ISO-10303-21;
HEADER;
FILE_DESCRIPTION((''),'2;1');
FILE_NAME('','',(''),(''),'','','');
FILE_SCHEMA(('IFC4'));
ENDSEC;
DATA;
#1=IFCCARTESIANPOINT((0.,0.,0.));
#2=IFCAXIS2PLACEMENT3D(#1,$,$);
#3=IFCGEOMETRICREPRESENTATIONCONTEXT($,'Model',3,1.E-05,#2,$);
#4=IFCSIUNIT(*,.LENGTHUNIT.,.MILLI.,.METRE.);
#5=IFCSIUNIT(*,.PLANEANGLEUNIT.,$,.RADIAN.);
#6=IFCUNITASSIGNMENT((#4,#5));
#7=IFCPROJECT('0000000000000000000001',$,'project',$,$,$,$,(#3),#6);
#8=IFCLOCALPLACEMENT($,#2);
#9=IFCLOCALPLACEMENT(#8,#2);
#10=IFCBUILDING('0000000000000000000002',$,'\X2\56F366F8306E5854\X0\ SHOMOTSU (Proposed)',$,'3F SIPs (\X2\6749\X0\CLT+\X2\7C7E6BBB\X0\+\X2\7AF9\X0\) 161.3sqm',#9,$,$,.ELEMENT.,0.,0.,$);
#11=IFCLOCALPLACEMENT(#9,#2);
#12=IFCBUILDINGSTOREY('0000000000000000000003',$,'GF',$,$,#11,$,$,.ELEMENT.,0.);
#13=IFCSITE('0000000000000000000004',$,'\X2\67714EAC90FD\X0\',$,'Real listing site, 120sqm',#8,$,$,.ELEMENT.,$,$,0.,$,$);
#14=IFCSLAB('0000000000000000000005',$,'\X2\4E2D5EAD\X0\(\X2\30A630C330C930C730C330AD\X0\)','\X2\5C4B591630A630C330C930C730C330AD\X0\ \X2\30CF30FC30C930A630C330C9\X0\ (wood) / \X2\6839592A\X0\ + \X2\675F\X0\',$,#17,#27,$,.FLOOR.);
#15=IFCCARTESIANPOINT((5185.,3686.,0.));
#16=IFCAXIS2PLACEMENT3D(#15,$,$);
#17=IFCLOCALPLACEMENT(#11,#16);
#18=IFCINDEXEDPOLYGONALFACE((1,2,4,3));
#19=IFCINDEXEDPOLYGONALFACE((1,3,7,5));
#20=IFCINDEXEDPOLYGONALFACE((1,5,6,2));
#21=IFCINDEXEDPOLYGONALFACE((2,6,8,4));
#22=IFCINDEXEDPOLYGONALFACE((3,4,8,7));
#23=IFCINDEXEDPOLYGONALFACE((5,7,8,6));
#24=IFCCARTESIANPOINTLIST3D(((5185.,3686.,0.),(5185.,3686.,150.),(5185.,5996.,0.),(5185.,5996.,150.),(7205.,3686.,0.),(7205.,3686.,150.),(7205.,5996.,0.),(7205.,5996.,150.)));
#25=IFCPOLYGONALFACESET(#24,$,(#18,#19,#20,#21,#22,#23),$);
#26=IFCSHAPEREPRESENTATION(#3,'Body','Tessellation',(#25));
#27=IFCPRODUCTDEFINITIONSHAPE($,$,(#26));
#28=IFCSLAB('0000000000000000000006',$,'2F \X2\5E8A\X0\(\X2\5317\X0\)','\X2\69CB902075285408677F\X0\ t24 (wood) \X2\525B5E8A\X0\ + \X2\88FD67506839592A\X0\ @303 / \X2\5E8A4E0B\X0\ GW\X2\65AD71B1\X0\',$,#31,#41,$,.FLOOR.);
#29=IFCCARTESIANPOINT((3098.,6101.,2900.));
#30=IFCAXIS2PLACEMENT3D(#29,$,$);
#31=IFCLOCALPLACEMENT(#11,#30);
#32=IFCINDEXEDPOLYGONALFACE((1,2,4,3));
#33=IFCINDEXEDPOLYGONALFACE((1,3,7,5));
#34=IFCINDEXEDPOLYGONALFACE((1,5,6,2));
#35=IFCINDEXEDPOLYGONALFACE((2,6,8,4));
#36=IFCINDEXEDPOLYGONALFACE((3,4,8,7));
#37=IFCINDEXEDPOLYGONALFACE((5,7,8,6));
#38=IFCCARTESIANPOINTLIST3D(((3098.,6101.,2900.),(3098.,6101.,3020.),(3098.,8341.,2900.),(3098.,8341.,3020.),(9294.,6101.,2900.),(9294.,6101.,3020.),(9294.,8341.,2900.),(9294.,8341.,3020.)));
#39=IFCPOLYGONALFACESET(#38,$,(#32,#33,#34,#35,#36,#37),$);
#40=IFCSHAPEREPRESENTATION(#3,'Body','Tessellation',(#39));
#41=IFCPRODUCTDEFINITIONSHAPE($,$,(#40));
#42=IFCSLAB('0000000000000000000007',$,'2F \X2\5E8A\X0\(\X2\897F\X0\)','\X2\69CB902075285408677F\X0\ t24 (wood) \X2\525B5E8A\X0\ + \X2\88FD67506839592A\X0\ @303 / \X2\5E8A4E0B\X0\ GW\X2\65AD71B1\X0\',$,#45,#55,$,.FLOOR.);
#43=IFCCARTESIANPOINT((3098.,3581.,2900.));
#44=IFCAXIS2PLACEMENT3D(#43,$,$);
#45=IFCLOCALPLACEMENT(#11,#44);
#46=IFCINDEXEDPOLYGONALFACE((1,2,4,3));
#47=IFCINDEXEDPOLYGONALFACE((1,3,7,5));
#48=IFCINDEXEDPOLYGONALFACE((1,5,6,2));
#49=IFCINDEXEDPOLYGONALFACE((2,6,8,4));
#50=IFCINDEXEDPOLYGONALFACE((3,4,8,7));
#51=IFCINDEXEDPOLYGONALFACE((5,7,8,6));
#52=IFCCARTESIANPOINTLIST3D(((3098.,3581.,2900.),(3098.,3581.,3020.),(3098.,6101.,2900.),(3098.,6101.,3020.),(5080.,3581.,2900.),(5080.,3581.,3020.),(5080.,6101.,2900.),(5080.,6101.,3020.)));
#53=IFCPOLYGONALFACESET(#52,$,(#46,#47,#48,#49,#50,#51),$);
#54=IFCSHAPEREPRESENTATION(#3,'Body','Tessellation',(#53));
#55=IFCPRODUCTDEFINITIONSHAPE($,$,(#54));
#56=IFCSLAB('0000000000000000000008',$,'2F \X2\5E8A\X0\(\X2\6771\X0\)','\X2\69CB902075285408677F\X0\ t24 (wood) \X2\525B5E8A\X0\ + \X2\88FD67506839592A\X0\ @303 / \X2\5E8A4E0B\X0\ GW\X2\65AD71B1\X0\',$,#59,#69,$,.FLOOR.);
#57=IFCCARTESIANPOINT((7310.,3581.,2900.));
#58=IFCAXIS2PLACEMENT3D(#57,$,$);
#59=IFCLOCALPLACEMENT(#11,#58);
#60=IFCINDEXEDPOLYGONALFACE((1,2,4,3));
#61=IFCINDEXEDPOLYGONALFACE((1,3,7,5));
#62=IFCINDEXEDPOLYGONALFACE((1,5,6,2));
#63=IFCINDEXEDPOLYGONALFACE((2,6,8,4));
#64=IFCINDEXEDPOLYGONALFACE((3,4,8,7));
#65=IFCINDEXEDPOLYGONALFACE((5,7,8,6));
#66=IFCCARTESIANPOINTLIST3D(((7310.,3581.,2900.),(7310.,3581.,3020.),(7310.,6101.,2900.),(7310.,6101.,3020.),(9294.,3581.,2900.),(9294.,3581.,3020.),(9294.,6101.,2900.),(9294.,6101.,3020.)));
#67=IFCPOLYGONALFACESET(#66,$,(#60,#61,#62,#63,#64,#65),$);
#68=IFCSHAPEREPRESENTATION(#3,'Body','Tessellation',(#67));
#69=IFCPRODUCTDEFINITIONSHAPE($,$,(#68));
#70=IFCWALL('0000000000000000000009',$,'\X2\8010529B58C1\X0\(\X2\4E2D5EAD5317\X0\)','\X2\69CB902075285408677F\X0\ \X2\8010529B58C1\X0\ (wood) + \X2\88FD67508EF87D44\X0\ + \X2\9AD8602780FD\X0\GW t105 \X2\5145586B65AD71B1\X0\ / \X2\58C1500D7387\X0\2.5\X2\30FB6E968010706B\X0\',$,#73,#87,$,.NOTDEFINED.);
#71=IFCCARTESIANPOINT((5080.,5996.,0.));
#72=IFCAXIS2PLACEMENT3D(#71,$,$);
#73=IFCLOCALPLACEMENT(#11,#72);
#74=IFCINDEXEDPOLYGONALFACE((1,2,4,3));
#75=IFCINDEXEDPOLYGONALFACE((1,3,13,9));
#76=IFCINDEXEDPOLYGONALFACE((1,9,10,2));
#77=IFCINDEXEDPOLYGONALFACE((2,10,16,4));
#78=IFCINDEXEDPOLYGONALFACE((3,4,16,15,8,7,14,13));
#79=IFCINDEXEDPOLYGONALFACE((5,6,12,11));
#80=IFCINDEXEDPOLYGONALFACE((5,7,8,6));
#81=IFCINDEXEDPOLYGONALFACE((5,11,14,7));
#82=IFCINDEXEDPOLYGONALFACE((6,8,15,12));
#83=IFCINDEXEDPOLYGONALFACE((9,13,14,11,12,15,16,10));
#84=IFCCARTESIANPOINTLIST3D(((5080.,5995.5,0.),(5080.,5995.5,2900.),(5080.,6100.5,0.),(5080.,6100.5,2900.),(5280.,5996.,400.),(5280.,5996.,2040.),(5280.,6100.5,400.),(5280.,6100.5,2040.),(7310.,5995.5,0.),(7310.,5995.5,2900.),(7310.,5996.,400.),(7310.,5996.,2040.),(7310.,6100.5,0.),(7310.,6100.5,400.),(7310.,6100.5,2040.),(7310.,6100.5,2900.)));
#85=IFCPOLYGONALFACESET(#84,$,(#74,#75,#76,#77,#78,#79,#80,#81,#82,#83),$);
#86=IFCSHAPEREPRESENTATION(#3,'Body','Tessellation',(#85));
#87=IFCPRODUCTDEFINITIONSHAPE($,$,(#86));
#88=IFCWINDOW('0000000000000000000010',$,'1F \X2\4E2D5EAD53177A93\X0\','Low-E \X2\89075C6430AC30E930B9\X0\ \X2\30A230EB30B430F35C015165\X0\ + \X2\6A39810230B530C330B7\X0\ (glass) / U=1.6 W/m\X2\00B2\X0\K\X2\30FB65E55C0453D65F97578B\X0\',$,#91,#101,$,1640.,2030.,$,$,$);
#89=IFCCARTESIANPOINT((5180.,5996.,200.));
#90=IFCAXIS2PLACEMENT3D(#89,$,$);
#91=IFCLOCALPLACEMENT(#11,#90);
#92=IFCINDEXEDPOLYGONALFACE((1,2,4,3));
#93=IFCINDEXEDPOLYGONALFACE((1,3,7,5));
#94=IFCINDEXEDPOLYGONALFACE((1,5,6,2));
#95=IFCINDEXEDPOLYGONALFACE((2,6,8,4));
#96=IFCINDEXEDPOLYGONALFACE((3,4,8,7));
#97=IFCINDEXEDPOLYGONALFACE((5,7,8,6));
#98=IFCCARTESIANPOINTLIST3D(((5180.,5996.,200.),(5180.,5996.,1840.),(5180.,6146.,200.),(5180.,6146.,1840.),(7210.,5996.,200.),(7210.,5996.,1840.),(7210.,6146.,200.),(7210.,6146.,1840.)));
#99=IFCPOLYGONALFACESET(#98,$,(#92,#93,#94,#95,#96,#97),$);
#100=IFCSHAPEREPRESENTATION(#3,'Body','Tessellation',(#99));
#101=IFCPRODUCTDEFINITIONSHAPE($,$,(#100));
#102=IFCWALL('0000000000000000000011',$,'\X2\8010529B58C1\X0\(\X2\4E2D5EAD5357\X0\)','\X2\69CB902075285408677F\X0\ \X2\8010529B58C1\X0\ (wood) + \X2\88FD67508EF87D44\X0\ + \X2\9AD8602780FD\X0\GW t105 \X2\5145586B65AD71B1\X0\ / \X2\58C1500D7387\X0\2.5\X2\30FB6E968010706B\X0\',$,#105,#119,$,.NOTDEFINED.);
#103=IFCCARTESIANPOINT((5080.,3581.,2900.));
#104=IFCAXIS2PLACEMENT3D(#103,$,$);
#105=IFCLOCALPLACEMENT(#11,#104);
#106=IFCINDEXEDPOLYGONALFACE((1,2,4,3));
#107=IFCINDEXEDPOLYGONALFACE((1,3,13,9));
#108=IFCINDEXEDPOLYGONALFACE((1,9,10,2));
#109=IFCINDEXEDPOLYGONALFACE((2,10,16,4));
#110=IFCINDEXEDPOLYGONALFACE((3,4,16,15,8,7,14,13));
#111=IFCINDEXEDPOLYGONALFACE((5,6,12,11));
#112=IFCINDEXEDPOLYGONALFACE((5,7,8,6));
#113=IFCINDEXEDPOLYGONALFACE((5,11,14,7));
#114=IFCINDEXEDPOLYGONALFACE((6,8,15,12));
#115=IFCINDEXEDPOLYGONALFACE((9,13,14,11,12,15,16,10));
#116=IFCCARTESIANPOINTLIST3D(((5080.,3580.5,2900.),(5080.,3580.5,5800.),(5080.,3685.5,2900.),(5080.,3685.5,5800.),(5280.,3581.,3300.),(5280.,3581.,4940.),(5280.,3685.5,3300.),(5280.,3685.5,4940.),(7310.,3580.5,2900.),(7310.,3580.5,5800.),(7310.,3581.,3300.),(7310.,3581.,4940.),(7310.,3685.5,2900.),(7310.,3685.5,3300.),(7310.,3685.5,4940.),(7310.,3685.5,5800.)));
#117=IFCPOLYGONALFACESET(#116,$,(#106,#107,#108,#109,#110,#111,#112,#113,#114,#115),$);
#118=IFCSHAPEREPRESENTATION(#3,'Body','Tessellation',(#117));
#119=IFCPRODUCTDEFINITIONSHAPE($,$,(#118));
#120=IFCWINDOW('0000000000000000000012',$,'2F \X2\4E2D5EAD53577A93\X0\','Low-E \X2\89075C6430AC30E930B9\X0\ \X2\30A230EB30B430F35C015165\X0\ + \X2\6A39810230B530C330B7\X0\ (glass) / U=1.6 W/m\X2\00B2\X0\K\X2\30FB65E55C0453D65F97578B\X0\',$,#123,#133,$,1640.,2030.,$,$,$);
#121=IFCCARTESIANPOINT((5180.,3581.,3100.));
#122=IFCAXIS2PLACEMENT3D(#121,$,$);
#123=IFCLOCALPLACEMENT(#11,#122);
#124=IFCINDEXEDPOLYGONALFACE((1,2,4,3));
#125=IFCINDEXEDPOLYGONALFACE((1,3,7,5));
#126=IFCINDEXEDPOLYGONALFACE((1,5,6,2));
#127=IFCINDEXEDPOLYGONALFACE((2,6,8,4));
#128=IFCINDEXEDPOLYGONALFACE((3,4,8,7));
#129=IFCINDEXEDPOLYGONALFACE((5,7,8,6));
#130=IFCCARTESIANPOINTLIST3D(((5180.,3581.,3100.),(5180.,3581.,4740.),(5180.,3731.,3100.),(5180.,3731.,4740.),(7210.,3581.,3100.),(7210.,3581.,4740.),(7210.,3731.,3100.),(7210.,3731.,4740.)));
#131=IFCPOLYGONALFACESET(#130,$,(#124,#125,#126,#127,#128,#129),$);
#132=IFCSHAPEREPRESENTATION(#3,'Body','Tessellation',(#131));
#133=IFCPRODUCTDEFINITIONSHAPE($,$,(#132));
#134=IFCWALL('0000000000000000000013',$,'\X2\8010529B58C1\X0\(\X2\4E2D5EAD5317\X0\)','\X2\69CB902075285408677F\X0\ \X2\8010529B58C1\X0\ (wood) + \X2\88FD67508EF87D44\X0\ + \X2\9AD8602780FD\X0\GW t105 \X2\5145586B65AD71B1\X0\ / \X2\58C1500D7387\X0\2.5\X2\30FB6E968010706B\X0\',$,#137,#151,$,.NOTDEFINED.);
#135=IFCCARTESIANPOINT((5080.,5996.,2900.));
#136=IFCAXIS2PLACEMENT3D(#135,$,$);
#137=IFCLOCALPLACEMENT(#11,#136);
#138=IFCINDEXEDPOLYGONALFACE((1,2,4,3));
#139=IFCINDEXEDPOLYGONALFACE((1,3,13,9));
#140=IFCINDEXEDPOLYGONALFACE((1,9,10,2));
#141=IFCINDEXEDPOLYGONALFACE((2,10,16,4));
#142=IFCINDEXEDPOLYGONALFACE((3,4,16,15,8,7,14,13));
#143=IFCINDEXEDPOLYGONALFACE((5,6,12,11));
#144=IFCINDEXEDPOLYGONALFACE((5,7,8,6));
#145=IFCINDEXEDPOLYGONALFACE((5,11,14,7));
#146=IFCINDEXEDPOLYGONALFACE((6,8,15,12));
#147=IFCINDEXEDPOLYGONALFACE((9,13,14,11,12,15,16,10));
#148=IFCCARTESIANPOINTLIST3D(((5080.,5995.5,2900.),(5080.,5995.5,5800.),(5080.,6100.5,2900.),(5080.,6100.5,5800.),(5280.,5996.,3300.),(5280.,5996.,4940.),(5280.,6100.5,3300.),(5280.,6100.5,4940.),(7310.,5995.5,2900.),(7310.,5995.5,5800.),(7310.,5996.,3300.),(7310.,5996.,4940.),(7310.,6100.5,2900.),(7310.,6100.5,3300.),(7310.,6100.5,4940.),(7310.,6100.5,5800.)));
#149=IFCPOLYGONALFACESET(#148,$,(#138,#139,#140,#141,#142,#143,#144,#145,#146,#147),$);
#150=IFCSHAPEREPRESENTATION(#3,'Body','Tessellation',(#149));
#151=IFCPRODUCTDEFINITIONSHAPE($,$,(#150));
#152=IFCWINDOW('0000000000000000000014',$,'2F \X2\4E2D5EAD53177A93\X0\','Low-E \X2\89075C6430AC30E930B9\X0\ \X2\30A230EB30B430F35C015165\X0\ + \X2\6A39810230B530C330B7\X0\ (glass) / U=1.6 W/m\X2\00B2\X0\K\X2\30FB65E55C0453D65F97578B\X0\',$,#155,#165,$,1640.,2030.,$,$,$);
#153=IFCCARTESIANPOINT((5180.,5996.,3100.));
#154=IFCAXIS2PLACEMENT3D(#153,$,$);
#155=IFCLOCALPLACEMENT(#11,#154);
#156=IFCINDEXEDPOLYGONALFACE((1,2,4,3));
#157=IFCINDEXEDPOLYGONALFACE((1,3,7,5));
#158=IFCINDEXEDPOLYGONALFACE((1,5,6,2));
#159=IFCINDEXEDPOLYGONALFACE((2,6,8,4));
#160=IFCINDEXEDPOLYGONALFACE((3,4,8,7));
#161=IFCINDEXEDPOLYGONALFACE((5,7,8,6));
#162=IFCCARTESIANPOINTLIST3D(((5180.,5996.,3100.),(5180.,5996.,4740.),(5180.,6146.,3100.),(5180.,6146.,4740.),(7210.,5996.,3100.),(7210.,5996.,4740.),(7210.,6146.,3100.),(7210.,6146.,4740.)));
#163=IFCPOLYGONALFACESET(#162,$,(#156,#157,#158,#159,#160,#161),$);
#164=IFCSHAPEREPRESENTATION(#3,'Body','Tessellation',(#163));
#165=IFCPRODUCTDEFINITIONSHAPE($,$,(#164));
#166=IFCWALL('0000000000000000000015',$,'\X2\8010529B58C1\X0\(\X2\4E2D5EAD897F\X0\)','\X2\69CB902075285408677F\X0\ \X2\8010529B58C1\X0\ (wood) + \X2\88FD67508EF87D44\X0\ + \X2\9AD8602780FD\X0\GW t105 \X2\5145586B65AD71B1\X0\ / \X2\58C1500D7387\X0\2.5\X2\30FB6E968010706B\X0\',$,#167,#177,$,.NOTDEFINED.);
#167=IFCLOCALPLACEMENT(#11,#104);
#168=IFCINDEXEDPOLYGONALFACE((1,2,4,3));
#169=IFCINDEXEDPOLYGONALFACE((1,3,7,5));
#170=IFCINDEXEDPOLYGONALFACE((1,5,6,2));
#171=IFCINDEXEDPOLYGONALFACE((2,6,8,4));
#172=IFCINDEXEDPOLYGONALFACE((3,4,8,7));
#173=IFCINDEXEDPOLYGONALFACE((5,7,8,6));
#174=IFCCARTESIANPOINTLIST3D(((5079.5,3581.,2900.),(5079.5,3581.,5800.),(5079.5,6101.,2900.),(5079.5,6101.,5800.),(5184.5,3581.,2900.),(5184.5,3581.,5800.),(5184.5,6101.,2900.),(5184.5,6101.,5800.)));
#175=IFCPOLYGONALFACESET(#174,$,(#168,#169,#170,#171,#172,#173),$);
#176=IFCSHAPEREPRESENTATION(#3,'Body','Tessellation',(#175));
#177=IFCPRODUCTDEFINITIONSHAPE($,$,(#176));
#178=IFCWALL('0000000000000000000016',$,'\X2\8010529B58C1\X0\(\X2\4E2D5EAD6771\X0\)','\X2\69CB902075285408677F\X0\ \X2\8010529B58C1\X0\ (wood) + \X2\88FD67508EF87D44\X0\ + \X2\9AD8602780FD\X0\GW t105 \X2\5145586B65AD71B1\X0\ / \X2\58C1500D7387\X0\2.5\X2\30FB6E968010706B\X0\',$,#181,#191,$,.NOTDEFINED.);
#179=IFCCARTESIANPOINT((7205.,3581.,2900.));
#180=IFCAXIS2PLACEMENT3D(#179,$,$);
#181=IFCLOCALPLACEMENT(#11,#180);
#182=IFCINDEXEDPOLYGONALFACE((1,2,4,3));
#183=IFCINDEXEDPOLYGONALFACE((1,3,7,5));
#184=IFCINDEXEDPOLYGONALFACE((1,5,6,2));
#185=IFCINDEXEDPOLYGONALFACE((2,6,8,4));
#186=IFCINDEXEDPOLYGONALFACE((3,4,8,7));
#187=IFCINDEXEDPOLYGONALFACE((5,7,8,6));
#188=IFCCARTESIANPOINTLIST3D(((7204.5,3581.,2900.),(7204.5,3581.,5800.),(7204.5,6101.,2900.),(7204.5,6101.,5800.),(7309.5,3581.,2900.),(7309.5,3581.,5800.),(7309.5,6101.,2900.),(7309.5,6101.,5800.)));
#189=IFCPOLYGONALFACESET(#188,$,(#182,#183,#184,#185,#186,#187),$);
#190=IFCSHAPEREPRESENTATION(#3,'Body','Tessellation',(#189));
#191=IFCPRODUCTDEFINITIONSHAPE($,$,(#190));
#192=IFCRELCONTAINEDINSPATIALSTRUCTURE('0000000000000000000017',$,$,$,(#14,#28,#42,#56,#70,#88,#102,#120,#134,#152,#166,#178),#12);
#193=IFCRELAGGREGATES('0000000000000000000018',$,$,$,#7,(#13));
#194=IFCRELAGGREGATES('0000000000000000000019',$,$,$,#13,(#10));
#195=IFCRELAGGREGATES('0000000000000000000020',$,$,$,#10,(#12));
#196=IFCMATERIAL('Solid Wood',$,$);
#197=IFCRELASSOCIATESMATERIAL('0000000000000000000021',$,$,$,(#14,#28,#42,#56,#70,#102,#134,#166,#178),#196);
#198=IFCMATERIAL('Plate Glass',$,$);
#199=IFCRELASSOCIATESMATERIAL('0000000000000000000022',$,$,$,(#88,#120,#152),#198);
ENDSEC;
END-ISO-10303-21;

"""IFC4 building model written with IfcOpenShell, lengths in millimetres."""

from ifc_helpers import new_model, si_unit, frame, frame_2d, origin, place, context, project, spatial, rectangle, extrude, material, element, fill, save


model = new_model("IFC4")

# Units and contexts
model_context = context("Model", 3, precision=1e-05, world=origin())
ifc_project = project(units=[si_unit("LENGTHUNIT", "METRE", prefix="MILLI"), si_unit("PLANEANGLEUNIT", "RADIAN")], contexts=[model_context])

# Site, building, storey
site_placement = place(None, origin())
site = spatial("IfcSite", under=ifc_project, at=site_placement, Name="東京都", ObjectType="Real listing site, 120sqm", CompositionType="ELEMENT", RefElevation=0.0)
building_placement = place(site_placement, origin())
building = spatial("IfcBuilding", under=site, at=building_placement, Name="図書の塔 SHOMOTSU (Proposed)", ObjectType="3F SIPs (杉CLT+籾殻+竹) 161.3sqm", CompositionType="ELEMENT", ElevationOfRefHeight=0.0, ElevationOfTerrain=0.0)
storey_placement = place(building_placement, origin())
storey = spatial("IfcBuildingStorey", under=building, at=storey_placement, Name="GF", CompositionType="ELEMENT", Elevation=0.0)

# Slabs
ifc_material_1 = material(Name="Solid Wood")
slab_1_placement = place(storey_placement, frame((5185.0, 3686.0, 0.0)))
element("IfcSlab", 1, at=slab_1_placement, inside=storey, material=ifc_material_1, Name="中庭(ウッドデッキ)", Description="屋外ウッドデッキ ハードウッド (wood) / 根太 + 束", PredefinedType="FLOOR", context=model_context, shape_type="SweptSolid", body=[
    extrude(rectangle(XDim=2020.0, YDim=2310.0, at=frame_2d((1010.0, 1155.0))), frame((5185.0, 3686.0, 0.0)), (0.0, 0.0, 1.0), 150.0),
])
slab_2_placement = place(storey_placement, frame((3098.0, 6101.0, 2900.0)))
element("IfcSlab", 2, at=slab_2_placement, inside=storey, material=ifc_material_1, Name="2F 床(北)", Description="構造用合板 t24 (wood) 剛床 + 製材根太 @303 / 床下 GW断熱", PredefinedType="FLOOR", context=model_context, shape_type="SweptSolid", body=[
    extrude(rectangle(XDim=6196.0, YDim=2240.0, at=frame_2d((3098.0, 1120.0))), frame((3098.0, 6101.0, 2900.0)), (0.0, 0.0, 1.0), 120.0),
])
slab_3_placement = place(storey_placement, frame((3098.0, 3581.0, 2900.0)))
element("IfcSlab", 3, at=slab_3_placement, inside=storey, material=ifc_material_1, Name="2F 床(西)", Description="構造用合板 t24 (wood) 剛床 + 製材根太 @303 / 床下 GW断熱", PredefinedType="FLOOR", context=model_context, shape_type="SweptSolid", body=[
    extrude(rectangle(XDim=1982.0, YDim=2520.0, at=frame_2d((991.0, 1260.0))), frame((3098.0, 3581.0, 2900.0)), (0.0, 0.0, 1.0), 120.0),
])
slab_4_placement = place(storey_placement, frame((7310.0, 3581.0, 2900.0)))
element("IfcSlab", 4, at=slab_4_placement, inside=storey, material=ifc_material_1, Name="2F 床(東)", Description="構造用合板 t24 (wood) 剛床 + 製材根太 @303 / 床下 GW断熱", PredefinedType="FLOOR", context=model_context, shape_type="SweptSolid", body=[
    extrude(rectangle(XDim=1984.0, YDim=2520.0, at=frame_2d((992.0, 1260.0))), frame((7310.0, 3581.0, 2900.0)), (0.0, 0.0, 1.0), 120.0),
])

# Wall, opening, window
wall_1_placement = place(storey_placement, frame((5080.0, 5996.0, 0.0)))
wall_1 = element("IfcWall", 5, at=wall_1_placement, inside=storey, material=ifc_material_1, Name="耐力壁(中庭北)", Description="構造用合板 耐力壁 (wood) + 製材軸組 + 高性能GW t105 充填断熱 / 壁倍率2.5・準耐火", PredefinedType="NOTDEFINED", context=model_context, shape_type="SweptSolid", body=[
    extrude(rectangle(XDim=2230.0, YDim=105.0, at=frame_2d((1115.0, 52.0))), frame((5080.0, 5996.0, 0.0)), (0.0, 0.0, 1.0), 2900.0),
])
opening_1_placement = place(storey_placement, frame((5180.0, 5996.0, 200.0)))
opening_1 = element("IfcOpeningElement", 6, at=opening_1_placement, cuts=wall_1, PredefinedType="NOTDEFINED", context=model_context, shape_type="SweptSolid", body=[
    extrude(rectangle(XDim=2030.0, YDim=150.0, at=frame_2d((1015.0, 75.0))), frame((5180.0, 5996.0, 200.0)), (0.0, 0.0, 1.0), 1640.0),
])
ifc_material_2 = material(Name="Plate Glass")
window_1_placement = place(storey_placement, frame((5180.0, 5996.0, 200.0)))
window_1 = element("IfcWindow", 7, at=window_1_placement, inside=storey, material=ifc_material_2, Name="1F 中庭北窓", Description="Low-E 複層ガラス アルゴン封入 + 樹脂サッシ (glass) / U=1.6 W/m²K・日射取得型", OverallHeight=1640.0, OverallWidth=2030.0, context=model_context, shape_type="SweptSolid", body=[
    extrude(rectangle(XDim=2030.0, YDim=150.0, at=frame_2d((1015.0, 75.0))), frame((5180.0, 5996.0, 200.0)), (0.0, 0.0, 1.0), 1640.0),
])
fill(opening_1, window_1)

# Walls, openings, windows
wall_2_placement = place(storey_placement, frame((5080.0, 3581.0, 2900.0)))
wall_2 = element("IfcWall", 8, at=wall_2_placement, inside=storey, material=ifc_material_1, Name="耐力壁(中庭南)", Description="構造用合板 耐力壁 (wood) + 製材軸組 + 高性能GW t105 充填断熱 / 壁倍率2.5・準耐火", PredefinedType="NOTDEFINED", context=model_context, shape_type="SweptSolid", body=[
    extrude(rectangle(XDim=2230.0, YDim=105.0, at=frame_2d((1115.0, 52.0))), frame((5080.0, 3581.0, 2900.0)), (0.0, 0.0, 1.0), 2900.0),
])
opening_2_placement = place(storey_placement, frame((5180.0, 3581.0, 3100.0)))
opening_2 = element("IfcOpeningElement", 9, at=opening_2_placement, cuts=wall_2, PredefinedType="NOTDEFINED", context=model_context, shape_type="SweptSolid", body=[
    extrude(rectangle(XDim=2030.0, YDim=150.0, at=frame_2d((1015.0, 75.0))), frame((5180.0, 3581.0, 3100.0)), (0.0, 0.0, 1.0), 1640.0),
])
window_2_placement = place(storey_placement, frame((5180.0, 3581.0, 3100.0)))
window_2 = element("IfcWindow", 10, at=window_2_placement, inside=storey, material=ifc_material_2, Name="2F 中庭南窓", Description="Low-E 複層ガラス アルゴン封入 + 樹脂サッシ (glass) / U=1.6 W/m²K・日射取得型", OverallHeight=1640.0, OverallWidth=2030.0, context=model_context, shape_type="SweptSolid", body=[
    extrude(rectangle(XDim=2030.0, YDim=150.0, at=frame_2d((1015.0, 75.0))), frame((5180.0, 3581.0, 3100.0)), (0.0, 0.0, 1.0), 1640.0),
])
fill(opening_2, window_2)
wall_3_placement = place(storey_placement, frame((5080.0, 5996.0, 2900.0)))
wall_3 = element("IfcWall", 11, at=wall_3_placement, inside=storey, material=ifc_material_1, Name="耐力壁(中庭北)", Description="構造用合板 耐力壁 (wood) + 製材軸組 + 高性能GW t105 充填断熱 / 壁倍率2.5・準耐火", PredefinedType="NOTDEFINED", context=model_context, shape_type="SweptSolid", body=[
    extrude(rectangle(XDim=2230.0, YDim=105.0, at=frame_2d((1115.0, 52.0))), frame((5080.0, 5996.0, 2900.0)), (0.0, 0.0, 1.0), 2900.0),
])
opening_3_placement = place(storey_placement, frame((5180.0, 5996.0, 3100.0)))
opening_3 = element("IfcOpeningElement", 12, at=opening_3_placement, cuts=wall_3, PredefinedType="NOTDEFINED", context=model_context, shape_type="SweptSolid", body=[
    extrude(rectangle(XDim=2030.0, YDim=150.0, at=frame_2d((1015.0, 75.0))), frame((5180.0, 5996.0, 3100.0)), (0.0, 0.0, 1.0), 1640.0),
])
window_3_placement = place(storey_placement, frame((5180.0, 5996.0, 3100.0)))
window_3 = element("IfcWindow", 13, at=window_3_placement, inside=storey, material=ifc_material_2, Name="2F 中庭北窓", Description="Low-E 複層ガラス アルゴン封入 + 樹脂サッシ (glass) / U=1.6 W/m²K・日射取得型", OverallHeight=1640.0, OverallWidth=2030.0, context=model_context, shape_type="SweptSolid", body=[
    extrude(rectangle(XDim=2030.0, YDim=150.0, at=frame_2d((1015.0, 75.0))), frame((5180.0, 5996.0, 3100.0)), (0.0, 0.0, 1.0), 1640.0),
])
fill(opening_3, window_3)

# Walls
wall_4_placement = place(storey_placement, frame((5080.0, 3581.0, 2900.0)))
element("IfcWall", 14, at=wall_4_placement, inside=storey, material=ifc_material_1, Name="耐力壁(中庭西)", Description="構造用合板 耐力壁 (wood) + 製材軸組 + 高性能GW t105 充填断熱 / 壁倍率2.5・準耐火", PredefinedType="NOTDEFINED", context=model_context, shape_type="SweptSolid", body=[
    extrude(rectangle(XDim=105.0, YDim=2520.0, at=frame_2d((52.0, 1260.0))), frame((5080.0, 3581.0, 2900.0)), (0.0, 0.0, 1.0), 2900.0),
])
wall_5_placement = place(storey_placement, frame((7205.0, 3581.0, 2900.0)))
element("IfcWall", 15, at=wall_5_placement, inside=storey, material=ifc_material_1, Name="耐力壁(中庭東)", Description="構造用合板 耐力壁 (wood) + 製材軸組 + 高性能GW t105 充填断熱 / 壁倍率2.5・準耐火", PredefinedType="NOTDEFINED", context=model_context, shape_type="SweptSolid", body=[
    extrude(rectangle(XDim=105.0, YDim=2520.0, at=frame_2d((52.0, 1260.0))), frame((7205.0, 3581.0, 2900.0)), (0.0, 0.0, 1.0), 2900.0),
])

save(model, "model.ifc")
